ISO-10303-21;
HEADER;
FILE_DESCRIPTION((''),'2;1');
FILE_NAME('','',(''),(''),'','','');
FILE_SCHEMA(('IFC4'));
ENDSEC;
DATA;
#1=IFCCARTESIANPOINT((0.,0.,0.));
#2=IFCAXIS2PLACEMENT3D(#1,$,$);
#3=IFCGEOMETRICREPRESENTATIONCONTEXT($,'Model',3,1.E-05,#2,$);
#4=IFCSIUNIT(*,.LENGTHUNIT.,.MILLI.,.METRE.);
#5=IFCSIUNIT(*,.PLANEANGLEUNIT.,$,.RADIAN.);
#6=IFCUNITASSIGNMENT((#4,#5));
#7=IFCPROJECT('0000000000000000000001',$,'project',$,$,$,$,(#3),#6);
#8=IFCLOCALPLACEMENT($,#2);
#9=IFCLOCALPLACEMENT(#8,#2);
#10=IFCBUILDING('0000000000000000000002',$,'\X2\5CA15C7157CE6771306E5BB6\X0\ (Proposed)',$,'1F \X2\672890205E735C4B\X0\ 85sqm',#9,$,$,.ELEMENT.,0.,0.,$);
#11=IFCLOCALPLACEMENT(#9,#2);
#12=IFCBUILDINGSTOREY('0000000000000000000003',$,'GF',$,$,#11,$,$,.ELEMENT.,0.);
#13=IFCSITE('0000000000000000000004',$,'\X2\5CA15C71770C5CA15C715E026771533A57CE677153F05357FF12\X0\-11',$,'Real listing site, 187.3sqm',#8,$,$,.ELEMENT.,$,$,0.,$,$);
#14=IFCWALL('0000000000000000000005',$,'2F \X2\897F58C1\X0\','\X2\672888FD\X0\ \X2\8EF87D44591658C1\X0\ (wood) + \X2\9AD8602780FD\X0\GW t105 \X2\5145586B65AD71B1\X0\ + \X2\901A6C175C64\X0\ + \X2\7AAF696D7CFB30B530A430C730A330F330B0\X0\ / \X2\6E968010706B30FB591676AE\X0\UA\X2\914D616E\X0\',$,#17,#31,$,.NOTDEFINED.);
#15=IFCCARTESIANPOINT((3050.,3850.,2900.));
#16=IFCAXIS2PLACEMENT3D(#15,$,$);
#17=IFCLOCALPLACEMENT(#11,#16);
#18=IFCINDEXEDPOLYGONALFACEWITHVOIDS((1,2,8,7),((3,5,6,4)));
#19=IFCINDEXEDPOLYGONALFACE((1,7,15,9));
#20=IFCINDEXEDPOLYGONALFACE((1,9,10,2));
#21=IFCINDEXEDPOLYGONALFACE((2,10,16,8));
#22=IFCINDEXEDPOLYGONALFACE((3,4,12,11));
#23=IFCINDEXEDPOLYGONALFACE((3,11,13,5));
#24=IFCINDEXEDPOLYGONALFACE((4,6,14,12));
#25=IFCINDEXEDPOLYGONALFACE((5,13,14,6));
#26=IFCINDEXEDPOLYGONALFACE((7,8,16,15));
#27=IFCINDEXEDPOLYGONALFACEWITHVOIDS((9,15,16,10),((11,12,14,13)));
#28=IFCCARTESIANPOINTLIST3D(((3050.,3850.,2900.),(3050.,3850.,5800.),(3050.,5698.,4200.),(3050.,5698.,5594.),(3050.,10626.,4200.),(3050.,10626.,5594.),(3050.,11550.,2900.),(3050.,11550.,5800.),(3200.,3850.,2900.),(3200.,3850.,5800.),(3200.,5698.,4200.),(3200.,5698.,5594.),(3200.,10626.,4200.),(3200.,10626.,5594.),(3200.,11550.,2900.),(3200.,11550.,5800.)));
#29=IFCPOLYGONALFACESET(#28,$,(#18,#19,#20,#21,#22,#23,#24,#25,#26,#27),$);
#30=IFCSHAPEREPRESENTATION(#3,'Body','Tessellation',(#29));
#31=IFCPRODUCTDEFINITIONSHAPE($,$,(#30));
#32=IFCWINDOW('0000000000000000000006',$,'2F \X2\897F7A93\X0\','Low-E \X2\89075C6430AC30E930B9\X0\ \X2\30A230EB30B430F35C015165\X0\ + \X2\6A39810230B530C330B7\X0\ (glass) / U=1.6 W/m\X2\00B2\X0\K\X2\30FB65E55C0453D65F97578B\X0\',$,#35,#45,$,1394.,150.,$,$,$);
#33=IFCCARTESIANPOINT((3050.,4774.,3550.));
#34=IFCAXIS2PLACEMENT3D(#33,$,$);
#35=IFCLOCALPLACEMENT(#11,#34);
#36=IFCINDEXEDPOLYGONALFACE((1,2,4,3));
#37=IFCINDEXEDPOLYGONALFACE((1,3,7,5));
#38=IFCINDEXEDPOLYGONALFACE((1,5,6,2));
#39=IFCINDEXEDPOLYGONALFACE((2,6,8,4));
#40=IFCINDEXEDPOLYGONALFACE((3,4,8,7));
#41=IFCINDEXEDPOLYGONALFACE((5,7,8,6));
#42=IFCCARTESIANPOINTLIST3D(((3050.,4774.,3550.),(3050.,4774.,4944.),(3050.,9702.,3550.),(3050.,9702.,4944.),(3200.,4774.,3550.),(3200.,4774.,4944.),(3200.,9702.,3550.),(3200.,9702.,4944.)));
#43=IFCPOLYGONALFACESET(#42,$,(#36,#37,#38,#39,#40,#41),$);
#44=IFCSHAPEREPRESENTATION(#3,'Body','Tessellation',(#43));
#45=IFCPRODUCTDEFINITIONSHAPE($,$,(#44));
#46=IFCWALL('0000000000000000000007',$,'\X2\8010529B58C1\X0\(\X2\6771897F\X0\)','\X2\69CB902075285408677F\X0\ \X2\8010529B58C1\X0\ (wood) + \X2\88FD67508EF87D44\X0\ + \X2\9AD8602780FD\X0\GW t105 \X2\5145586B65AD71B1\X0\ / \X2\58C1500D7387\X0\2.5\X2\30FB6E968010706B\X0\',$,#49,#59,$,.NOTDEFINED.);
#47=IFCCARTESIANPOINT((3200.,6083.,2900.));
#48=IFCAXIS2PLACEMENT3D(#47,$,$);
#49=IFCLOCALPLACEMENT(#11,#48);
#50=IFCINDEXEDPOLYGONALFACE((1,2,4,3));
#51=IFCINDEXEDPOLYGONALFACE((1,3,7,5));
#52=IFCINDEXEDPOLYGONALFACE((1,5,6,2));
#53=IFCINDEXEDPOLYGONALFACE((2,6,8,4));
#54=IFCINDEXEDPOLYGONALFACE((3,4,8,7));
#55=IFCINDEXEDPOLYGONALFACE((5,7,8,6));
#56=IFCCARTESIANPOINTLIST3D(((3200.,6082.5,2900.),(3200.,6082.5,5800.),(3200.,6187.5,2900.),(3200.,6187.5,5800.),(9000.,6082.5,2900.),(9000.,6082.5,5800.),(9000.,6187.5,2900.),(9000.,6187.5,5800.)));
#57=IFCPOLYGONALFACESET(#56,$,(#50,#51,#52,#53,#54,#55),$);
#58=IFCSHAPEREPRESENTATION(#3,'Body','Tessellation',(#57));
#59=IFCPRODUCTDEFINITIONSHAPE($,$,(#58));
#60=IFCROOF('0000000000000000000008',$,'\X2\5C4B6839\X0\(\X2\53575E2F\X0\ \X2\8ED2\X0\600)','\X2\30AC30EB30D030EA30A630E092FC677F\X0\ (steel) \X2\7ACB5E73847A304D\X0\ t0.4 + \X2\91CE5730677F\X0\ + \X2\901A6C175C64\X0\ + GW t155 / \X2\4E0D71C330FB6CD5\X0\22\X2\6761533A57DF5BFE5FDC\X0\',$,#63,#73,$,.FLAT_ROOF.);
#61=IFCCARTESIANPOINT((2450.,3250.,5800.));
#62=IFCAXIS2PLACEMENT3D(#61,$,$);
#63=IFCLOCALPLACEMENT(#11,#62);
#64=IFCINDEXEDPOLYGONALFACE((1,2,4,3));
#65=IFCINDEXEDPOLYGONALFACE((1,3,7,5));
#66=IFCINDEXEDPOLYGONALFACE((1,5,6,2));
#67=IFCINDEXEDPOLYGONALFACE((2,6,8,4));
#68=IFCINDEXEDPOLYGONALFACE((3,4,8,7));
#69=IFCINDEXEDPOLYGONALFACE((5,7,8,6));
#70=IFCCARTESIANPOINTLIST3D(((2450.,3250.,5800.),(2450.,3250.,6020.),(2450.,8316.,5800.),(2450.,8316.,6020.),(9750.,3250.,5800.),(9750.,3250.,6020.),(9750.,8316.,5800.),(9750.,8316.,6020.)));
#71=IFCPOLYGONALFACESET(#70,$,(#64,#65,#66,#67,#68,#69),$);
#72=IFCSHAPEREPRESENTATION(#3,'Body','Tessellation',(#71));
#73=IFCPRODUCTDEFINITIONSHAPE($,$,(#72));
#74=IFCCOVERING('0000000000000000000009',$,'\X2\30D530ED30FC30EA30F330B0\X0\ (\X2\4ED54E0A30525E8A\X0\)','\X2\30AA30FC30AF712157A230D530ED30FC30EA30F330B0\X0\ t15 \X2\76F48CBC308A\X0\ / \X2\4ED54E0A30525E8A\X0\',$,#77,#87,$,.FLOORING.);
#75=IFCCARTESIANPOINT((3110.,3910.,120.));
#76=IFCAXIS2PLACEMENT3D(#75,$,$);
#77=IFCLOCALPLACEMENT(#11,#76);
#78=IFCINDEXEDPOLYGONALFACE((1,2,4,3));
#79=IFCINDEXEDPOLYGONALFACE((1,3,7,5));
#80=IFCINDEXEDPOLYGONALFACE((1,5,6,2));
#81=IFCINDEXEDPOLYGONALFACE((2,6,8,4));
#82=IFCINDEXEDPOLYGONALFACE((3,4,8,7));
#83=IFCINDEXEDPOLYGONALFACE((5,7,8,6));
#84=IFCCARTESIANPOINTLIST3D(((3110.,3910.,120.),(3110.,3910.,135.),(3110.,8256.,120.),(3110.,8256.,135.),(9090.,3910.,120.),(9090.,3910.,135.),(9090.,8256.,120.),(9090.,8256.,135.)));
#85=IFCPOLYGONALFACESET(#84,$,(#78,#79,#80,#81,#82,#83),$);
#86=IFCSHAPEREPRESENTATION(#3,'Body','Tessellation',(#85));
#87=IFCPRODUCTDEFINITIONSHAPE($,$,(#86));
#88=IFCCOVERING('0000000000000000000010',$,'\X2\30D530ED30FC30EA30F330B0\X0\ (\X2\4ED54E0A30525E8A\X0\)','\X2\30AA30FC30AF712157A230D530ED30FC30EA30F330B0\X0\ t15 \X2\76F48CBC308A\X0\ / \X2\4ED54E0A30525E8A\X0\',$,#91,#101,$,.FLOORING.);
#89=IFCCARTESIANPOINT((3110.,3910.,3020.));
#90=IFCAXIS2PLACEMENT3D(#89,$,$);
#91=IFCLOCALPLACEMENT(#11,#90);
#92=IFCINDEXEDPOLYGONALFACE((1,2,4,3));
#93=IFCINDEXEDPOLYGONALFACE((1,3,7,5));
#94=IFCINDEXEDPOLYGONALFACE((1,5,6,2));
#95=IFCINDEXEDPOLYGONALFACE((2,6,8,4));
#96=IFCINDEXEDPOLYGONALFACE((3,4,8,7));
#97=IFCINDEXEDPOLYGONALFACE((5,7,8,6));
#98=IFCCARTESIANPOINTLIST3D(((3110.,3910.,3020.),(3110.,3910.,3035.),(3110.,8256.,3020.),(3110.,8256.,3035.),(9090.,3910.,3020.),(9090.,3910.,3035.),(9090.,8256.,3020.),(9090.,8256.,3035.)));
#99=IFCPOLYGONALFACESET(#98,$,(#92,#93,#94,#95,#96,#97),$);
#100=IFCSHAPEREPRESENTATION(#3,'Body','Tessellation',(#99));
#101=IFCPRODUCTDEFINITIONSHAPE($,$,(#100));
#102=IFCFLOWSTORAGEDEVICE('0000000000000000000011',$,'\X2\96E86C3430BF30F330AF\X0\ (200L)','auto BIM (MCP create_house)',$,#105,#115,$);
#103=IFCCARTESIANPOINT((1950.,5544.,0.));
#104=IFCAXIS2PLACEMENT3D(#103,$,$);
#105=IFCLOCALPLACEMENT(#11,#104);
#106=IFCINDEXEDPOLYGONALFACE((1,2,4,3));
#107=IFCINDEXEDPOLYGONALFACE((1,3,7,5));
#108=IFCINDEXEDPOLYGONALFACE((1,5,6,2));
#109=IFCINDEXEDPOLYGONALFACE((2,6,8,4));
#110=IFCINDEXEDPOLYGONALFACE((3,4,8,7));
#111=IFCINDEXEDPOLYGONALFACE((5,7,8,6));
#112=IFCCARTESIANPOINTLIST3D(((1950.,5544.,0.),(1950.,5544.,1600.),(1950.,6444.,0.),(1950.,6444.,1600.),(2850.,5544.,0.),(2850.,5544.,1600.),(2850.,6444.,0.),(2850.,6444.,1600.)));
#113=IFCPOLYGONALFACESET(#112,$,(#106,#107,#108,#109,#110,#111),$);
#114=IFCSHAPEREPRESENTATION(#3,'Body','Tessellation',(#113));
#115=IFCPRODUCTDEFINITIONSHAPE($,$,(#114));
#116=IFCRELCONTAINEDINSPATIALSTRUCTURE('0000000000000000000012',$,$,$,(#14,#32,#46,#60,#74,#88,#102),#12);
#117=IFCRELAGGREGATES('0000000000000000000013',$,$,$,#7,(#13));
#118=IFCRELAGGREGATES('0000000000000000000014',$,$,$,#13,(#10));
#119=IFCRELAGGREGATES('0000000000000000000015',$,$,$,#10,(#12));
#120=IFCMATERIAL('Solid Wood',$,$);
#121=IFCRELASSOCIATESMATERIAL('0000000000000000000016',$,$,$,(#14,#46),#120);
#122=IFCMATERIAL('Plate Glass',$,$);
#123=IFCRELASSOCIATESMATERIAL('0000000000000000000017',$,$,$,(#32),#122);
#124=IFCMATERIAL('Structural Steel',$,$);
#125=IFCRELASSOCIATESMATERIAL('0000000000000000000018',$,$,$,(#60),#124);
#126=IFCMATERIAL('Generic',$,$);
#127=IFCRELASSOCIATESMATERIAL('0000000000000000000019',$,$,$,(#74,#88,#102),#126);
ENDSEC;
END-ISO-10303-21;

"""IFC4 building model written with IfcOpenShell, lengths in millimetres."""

from ifc_helpers import new_model, si_unit, frame, frame_2d, origin, place, context, project, spatial, rectangle, extrude, material, element, fill, save


model = new_model("IFC4")

# Units and contexts
model_context = context("Model", 3, precision=1e-05, world=origin())
ifc_project = project(units=[si_unit("LENGTHUNIT", "METRE", prefix="MILLI"), si_unit("PLANEANGLEUNIT", "RADIAN")], contexts=[model_context])

# Site, building, storey
site_placement = place(None, origin())
site = spatial("IfcSite", under=ifc_project, at=site_placement, Name="岡山県岡山市東区城東台南２-11", ObjectType="Real listing site, 187.3sqm", CompositionType="ELEMENT", RefElevation=0.0)
building_placement = place(site_placement, origin())
building = spatial("IfcBuilding", under=site, at=building_placement, Name="岡山城東の家 (Proposed)", ObjectType="1F 木造平屋 85sqm", CompositionType="ELEMENT", ElevationOfRefHeight=0.0, ElevationOfTerrain=0.0)
storey_placement = place(building_placement, origin())
storey = spatial("IfcBuildingStorey", under=building, at=storey_placement, Name="GF", CompositionType="ELEMENT", Elevation=0.0)

# Shared definitions
ifc_material_1 = material(Name="Solid Wood")
ifc_material_2 = material(Name="Generic")

# Shared definitions
ifc_material_3 = material(Name="Plate Glass")

# Wall, opening, window
wall_1_placement = place(storey_placement, frame((3050.0, 3850.0, 2900.0)))
wall_1 = element("IfcWall", 1, at=wall_1_placement, inside=storey, material=ifc_material_1, Name="2F 西壁", Description="木製 軸組外壁 (wood) + 高性能GW t105 充填断熱 + 通気層 + 窯業系サイディング / 準耐火・外皮UA配慮", PredefinedType="NOTDEFINED", context=model_context, shape_type="SweptSolid", body=[
    extrude(rectangle(XDim=150.0, YDim=7700.0, at=frame_2d((75.0, 3850.0))), frame((3050.0, 3850.0, 2900.0)), (0.0, 0.0, 1.0), 2900.0),
])
opening_1_placement = place(storey_placement, frame((3050.0, 4774.0, 3550.0)))
opening_1 = element("IfcOpeningElement", 2, at=opening_1_placement, cuts=wall_1, PredefinedType="NOTDEFINED", context=model_context, shape_type="SweptSolid", body=[
    extrude(rectangle(XDim=150.0, YDim=4928.0, at=frame_2d((75.0, 2464.0))), frame((3050.0, 4774.0, 3550.0)), (0.0, 0.0, 1.0), 1394.0),
])
window_1_placement = place(storey_placement, frame((3050.0, 4774.0, 3550.0)))
window_1 = element("IfcWindow", 3, at=window_1_placement, inside=storey, material=ifc_material_3, Name="2F 西窓", Description="Low-E 複層ガラス アルゴン封入 + 樹脂サッシ (glass) / U=1.6 W/m²K・日射取得型", OverallHeight=1394.0, OverallWidth=150.0, context=model_context, shape_type="SweptSolid", body=[
    extrude(rectangle(XDim=150.0, YDim=4928.0, at=frame_2d((75.0, 2464.0))), frame((3050.0, 4774.0, 3550.0)), (0.0, 0.0, 1.0), 1394.0),
])
fill(opening_1, window_1)

# Wall
wall_2_placement = place(storey_placement, frame((3200.0, 6083.0, 2900.0)))
element("IfcWall", 4, at=wall_2_placement, inside=storey, material=ifc_material_1, Name="耐力壁(東西)", Description="構造用合板 耐力壁 (wood) + 製材軸組 + 高性能GW t105 充填断熱 / 壁倍率2.5・準耐火", PredefinedType="NOTDEFINED", context=model_context, shape_type="SweptSolid", body=[
    extrude(rectangle(XDim=5800.0, YDim=105.0, at=frame_2d((2900.0, 52.0))), frame((3200.0, 6083.0, 2900.0)), (0.0, 0.0, 1.0), 2900.0),
])

# Roof
ifc_material_4 = material(Name="Structural Steel")
for number, where, name in (
    (5, (2450.0, 3250.0, 5800.0), "屋根(南帯 軒600)"),
):
    element("IfcRoof", number, at=place(storey_placement, frame(where)), inside=storey, material=ifc_material_4, Name=name, Description="ガルバリウム鋼板 (steel) 立平葺き t0.4 + 野地板 + 通気層 + GW t155 / 不燃・法22条区域対応", PredefinedType="FLAT_ROOF", context=model_context, shape_type="SweptSolid", body=[
        extrude(rectangle(XDim=7300.0, YDim=5066.0, at=frame_2d((3650.0, 2533.0))), frame((2450.0, 3250.0, 5800.0)), (0.0, 0.0, 1.0), 220.0),
    ])

# Coverings
covering_1_placement = place(storey_placement, frame((3110.0, 3910.0, 120.0)))
element("IfcCovering", 6, at=covering_1_placement, inside=storey, material=ifc_material_2, Name="フローリング (仕上げ床)", Description="オーク無垢フローリング t15 直貼り / 仕上げ床", PredefinedType="FLOORING", context=model_context, shape_type="SweptSolid", body=[
    extrude(rectangle(XDim=5980.0, YDim=4346.0, at=frame_2d((2990.0, 2173.0))), frame((3110.0, 3910.0, 120.0)), (0.0, 0.0, 1.0), 15.0),
])
covering_2_placement = place(storey_placement, frame((3110.0, 3910.0, 3020.0)))
element("IfcCovering", 7, at=covering_2_placement, inside=storey, material=ifc_material_2, Name="フローリング (仕上げ床)", Description="オーク無垢フローリング t15 直貼り / 仕上げ床", PredefinedType="FLOORING", context=model_context, shape_type="SweptSolid", body=[
    extrude(rectangle(XDim=5980.0, YDim=4346.0, at=frame_2d((2990.0, 2173.0))), frame((3110.0, 3910.0, 3020.0)), (0.0, 0.0, 1.0), 15.0),
])

# Flow storage device
flow_storage_device_placement = place(storey_placement, frame((1950.0, 5544.0, 0.0)))
element("IfcFlowStorageDevice", 8, at=flow_storage_device_placement, inside=storey, material=ifc_material_2, Name="雨水タンク (200L)", Description="auto BIM (MCP create_house)", context=model_context, shape_type="SweptSolid", body=[
    extrude(rectangle(XDim=900.0, YDim=900.0, at=frame_2d((450.0, 450.0))), frame((1950.0, 5544.0, 0.0)), (0.0, 0.0, 1.0), 1600.0),
])

save(model, "model.ifc")
